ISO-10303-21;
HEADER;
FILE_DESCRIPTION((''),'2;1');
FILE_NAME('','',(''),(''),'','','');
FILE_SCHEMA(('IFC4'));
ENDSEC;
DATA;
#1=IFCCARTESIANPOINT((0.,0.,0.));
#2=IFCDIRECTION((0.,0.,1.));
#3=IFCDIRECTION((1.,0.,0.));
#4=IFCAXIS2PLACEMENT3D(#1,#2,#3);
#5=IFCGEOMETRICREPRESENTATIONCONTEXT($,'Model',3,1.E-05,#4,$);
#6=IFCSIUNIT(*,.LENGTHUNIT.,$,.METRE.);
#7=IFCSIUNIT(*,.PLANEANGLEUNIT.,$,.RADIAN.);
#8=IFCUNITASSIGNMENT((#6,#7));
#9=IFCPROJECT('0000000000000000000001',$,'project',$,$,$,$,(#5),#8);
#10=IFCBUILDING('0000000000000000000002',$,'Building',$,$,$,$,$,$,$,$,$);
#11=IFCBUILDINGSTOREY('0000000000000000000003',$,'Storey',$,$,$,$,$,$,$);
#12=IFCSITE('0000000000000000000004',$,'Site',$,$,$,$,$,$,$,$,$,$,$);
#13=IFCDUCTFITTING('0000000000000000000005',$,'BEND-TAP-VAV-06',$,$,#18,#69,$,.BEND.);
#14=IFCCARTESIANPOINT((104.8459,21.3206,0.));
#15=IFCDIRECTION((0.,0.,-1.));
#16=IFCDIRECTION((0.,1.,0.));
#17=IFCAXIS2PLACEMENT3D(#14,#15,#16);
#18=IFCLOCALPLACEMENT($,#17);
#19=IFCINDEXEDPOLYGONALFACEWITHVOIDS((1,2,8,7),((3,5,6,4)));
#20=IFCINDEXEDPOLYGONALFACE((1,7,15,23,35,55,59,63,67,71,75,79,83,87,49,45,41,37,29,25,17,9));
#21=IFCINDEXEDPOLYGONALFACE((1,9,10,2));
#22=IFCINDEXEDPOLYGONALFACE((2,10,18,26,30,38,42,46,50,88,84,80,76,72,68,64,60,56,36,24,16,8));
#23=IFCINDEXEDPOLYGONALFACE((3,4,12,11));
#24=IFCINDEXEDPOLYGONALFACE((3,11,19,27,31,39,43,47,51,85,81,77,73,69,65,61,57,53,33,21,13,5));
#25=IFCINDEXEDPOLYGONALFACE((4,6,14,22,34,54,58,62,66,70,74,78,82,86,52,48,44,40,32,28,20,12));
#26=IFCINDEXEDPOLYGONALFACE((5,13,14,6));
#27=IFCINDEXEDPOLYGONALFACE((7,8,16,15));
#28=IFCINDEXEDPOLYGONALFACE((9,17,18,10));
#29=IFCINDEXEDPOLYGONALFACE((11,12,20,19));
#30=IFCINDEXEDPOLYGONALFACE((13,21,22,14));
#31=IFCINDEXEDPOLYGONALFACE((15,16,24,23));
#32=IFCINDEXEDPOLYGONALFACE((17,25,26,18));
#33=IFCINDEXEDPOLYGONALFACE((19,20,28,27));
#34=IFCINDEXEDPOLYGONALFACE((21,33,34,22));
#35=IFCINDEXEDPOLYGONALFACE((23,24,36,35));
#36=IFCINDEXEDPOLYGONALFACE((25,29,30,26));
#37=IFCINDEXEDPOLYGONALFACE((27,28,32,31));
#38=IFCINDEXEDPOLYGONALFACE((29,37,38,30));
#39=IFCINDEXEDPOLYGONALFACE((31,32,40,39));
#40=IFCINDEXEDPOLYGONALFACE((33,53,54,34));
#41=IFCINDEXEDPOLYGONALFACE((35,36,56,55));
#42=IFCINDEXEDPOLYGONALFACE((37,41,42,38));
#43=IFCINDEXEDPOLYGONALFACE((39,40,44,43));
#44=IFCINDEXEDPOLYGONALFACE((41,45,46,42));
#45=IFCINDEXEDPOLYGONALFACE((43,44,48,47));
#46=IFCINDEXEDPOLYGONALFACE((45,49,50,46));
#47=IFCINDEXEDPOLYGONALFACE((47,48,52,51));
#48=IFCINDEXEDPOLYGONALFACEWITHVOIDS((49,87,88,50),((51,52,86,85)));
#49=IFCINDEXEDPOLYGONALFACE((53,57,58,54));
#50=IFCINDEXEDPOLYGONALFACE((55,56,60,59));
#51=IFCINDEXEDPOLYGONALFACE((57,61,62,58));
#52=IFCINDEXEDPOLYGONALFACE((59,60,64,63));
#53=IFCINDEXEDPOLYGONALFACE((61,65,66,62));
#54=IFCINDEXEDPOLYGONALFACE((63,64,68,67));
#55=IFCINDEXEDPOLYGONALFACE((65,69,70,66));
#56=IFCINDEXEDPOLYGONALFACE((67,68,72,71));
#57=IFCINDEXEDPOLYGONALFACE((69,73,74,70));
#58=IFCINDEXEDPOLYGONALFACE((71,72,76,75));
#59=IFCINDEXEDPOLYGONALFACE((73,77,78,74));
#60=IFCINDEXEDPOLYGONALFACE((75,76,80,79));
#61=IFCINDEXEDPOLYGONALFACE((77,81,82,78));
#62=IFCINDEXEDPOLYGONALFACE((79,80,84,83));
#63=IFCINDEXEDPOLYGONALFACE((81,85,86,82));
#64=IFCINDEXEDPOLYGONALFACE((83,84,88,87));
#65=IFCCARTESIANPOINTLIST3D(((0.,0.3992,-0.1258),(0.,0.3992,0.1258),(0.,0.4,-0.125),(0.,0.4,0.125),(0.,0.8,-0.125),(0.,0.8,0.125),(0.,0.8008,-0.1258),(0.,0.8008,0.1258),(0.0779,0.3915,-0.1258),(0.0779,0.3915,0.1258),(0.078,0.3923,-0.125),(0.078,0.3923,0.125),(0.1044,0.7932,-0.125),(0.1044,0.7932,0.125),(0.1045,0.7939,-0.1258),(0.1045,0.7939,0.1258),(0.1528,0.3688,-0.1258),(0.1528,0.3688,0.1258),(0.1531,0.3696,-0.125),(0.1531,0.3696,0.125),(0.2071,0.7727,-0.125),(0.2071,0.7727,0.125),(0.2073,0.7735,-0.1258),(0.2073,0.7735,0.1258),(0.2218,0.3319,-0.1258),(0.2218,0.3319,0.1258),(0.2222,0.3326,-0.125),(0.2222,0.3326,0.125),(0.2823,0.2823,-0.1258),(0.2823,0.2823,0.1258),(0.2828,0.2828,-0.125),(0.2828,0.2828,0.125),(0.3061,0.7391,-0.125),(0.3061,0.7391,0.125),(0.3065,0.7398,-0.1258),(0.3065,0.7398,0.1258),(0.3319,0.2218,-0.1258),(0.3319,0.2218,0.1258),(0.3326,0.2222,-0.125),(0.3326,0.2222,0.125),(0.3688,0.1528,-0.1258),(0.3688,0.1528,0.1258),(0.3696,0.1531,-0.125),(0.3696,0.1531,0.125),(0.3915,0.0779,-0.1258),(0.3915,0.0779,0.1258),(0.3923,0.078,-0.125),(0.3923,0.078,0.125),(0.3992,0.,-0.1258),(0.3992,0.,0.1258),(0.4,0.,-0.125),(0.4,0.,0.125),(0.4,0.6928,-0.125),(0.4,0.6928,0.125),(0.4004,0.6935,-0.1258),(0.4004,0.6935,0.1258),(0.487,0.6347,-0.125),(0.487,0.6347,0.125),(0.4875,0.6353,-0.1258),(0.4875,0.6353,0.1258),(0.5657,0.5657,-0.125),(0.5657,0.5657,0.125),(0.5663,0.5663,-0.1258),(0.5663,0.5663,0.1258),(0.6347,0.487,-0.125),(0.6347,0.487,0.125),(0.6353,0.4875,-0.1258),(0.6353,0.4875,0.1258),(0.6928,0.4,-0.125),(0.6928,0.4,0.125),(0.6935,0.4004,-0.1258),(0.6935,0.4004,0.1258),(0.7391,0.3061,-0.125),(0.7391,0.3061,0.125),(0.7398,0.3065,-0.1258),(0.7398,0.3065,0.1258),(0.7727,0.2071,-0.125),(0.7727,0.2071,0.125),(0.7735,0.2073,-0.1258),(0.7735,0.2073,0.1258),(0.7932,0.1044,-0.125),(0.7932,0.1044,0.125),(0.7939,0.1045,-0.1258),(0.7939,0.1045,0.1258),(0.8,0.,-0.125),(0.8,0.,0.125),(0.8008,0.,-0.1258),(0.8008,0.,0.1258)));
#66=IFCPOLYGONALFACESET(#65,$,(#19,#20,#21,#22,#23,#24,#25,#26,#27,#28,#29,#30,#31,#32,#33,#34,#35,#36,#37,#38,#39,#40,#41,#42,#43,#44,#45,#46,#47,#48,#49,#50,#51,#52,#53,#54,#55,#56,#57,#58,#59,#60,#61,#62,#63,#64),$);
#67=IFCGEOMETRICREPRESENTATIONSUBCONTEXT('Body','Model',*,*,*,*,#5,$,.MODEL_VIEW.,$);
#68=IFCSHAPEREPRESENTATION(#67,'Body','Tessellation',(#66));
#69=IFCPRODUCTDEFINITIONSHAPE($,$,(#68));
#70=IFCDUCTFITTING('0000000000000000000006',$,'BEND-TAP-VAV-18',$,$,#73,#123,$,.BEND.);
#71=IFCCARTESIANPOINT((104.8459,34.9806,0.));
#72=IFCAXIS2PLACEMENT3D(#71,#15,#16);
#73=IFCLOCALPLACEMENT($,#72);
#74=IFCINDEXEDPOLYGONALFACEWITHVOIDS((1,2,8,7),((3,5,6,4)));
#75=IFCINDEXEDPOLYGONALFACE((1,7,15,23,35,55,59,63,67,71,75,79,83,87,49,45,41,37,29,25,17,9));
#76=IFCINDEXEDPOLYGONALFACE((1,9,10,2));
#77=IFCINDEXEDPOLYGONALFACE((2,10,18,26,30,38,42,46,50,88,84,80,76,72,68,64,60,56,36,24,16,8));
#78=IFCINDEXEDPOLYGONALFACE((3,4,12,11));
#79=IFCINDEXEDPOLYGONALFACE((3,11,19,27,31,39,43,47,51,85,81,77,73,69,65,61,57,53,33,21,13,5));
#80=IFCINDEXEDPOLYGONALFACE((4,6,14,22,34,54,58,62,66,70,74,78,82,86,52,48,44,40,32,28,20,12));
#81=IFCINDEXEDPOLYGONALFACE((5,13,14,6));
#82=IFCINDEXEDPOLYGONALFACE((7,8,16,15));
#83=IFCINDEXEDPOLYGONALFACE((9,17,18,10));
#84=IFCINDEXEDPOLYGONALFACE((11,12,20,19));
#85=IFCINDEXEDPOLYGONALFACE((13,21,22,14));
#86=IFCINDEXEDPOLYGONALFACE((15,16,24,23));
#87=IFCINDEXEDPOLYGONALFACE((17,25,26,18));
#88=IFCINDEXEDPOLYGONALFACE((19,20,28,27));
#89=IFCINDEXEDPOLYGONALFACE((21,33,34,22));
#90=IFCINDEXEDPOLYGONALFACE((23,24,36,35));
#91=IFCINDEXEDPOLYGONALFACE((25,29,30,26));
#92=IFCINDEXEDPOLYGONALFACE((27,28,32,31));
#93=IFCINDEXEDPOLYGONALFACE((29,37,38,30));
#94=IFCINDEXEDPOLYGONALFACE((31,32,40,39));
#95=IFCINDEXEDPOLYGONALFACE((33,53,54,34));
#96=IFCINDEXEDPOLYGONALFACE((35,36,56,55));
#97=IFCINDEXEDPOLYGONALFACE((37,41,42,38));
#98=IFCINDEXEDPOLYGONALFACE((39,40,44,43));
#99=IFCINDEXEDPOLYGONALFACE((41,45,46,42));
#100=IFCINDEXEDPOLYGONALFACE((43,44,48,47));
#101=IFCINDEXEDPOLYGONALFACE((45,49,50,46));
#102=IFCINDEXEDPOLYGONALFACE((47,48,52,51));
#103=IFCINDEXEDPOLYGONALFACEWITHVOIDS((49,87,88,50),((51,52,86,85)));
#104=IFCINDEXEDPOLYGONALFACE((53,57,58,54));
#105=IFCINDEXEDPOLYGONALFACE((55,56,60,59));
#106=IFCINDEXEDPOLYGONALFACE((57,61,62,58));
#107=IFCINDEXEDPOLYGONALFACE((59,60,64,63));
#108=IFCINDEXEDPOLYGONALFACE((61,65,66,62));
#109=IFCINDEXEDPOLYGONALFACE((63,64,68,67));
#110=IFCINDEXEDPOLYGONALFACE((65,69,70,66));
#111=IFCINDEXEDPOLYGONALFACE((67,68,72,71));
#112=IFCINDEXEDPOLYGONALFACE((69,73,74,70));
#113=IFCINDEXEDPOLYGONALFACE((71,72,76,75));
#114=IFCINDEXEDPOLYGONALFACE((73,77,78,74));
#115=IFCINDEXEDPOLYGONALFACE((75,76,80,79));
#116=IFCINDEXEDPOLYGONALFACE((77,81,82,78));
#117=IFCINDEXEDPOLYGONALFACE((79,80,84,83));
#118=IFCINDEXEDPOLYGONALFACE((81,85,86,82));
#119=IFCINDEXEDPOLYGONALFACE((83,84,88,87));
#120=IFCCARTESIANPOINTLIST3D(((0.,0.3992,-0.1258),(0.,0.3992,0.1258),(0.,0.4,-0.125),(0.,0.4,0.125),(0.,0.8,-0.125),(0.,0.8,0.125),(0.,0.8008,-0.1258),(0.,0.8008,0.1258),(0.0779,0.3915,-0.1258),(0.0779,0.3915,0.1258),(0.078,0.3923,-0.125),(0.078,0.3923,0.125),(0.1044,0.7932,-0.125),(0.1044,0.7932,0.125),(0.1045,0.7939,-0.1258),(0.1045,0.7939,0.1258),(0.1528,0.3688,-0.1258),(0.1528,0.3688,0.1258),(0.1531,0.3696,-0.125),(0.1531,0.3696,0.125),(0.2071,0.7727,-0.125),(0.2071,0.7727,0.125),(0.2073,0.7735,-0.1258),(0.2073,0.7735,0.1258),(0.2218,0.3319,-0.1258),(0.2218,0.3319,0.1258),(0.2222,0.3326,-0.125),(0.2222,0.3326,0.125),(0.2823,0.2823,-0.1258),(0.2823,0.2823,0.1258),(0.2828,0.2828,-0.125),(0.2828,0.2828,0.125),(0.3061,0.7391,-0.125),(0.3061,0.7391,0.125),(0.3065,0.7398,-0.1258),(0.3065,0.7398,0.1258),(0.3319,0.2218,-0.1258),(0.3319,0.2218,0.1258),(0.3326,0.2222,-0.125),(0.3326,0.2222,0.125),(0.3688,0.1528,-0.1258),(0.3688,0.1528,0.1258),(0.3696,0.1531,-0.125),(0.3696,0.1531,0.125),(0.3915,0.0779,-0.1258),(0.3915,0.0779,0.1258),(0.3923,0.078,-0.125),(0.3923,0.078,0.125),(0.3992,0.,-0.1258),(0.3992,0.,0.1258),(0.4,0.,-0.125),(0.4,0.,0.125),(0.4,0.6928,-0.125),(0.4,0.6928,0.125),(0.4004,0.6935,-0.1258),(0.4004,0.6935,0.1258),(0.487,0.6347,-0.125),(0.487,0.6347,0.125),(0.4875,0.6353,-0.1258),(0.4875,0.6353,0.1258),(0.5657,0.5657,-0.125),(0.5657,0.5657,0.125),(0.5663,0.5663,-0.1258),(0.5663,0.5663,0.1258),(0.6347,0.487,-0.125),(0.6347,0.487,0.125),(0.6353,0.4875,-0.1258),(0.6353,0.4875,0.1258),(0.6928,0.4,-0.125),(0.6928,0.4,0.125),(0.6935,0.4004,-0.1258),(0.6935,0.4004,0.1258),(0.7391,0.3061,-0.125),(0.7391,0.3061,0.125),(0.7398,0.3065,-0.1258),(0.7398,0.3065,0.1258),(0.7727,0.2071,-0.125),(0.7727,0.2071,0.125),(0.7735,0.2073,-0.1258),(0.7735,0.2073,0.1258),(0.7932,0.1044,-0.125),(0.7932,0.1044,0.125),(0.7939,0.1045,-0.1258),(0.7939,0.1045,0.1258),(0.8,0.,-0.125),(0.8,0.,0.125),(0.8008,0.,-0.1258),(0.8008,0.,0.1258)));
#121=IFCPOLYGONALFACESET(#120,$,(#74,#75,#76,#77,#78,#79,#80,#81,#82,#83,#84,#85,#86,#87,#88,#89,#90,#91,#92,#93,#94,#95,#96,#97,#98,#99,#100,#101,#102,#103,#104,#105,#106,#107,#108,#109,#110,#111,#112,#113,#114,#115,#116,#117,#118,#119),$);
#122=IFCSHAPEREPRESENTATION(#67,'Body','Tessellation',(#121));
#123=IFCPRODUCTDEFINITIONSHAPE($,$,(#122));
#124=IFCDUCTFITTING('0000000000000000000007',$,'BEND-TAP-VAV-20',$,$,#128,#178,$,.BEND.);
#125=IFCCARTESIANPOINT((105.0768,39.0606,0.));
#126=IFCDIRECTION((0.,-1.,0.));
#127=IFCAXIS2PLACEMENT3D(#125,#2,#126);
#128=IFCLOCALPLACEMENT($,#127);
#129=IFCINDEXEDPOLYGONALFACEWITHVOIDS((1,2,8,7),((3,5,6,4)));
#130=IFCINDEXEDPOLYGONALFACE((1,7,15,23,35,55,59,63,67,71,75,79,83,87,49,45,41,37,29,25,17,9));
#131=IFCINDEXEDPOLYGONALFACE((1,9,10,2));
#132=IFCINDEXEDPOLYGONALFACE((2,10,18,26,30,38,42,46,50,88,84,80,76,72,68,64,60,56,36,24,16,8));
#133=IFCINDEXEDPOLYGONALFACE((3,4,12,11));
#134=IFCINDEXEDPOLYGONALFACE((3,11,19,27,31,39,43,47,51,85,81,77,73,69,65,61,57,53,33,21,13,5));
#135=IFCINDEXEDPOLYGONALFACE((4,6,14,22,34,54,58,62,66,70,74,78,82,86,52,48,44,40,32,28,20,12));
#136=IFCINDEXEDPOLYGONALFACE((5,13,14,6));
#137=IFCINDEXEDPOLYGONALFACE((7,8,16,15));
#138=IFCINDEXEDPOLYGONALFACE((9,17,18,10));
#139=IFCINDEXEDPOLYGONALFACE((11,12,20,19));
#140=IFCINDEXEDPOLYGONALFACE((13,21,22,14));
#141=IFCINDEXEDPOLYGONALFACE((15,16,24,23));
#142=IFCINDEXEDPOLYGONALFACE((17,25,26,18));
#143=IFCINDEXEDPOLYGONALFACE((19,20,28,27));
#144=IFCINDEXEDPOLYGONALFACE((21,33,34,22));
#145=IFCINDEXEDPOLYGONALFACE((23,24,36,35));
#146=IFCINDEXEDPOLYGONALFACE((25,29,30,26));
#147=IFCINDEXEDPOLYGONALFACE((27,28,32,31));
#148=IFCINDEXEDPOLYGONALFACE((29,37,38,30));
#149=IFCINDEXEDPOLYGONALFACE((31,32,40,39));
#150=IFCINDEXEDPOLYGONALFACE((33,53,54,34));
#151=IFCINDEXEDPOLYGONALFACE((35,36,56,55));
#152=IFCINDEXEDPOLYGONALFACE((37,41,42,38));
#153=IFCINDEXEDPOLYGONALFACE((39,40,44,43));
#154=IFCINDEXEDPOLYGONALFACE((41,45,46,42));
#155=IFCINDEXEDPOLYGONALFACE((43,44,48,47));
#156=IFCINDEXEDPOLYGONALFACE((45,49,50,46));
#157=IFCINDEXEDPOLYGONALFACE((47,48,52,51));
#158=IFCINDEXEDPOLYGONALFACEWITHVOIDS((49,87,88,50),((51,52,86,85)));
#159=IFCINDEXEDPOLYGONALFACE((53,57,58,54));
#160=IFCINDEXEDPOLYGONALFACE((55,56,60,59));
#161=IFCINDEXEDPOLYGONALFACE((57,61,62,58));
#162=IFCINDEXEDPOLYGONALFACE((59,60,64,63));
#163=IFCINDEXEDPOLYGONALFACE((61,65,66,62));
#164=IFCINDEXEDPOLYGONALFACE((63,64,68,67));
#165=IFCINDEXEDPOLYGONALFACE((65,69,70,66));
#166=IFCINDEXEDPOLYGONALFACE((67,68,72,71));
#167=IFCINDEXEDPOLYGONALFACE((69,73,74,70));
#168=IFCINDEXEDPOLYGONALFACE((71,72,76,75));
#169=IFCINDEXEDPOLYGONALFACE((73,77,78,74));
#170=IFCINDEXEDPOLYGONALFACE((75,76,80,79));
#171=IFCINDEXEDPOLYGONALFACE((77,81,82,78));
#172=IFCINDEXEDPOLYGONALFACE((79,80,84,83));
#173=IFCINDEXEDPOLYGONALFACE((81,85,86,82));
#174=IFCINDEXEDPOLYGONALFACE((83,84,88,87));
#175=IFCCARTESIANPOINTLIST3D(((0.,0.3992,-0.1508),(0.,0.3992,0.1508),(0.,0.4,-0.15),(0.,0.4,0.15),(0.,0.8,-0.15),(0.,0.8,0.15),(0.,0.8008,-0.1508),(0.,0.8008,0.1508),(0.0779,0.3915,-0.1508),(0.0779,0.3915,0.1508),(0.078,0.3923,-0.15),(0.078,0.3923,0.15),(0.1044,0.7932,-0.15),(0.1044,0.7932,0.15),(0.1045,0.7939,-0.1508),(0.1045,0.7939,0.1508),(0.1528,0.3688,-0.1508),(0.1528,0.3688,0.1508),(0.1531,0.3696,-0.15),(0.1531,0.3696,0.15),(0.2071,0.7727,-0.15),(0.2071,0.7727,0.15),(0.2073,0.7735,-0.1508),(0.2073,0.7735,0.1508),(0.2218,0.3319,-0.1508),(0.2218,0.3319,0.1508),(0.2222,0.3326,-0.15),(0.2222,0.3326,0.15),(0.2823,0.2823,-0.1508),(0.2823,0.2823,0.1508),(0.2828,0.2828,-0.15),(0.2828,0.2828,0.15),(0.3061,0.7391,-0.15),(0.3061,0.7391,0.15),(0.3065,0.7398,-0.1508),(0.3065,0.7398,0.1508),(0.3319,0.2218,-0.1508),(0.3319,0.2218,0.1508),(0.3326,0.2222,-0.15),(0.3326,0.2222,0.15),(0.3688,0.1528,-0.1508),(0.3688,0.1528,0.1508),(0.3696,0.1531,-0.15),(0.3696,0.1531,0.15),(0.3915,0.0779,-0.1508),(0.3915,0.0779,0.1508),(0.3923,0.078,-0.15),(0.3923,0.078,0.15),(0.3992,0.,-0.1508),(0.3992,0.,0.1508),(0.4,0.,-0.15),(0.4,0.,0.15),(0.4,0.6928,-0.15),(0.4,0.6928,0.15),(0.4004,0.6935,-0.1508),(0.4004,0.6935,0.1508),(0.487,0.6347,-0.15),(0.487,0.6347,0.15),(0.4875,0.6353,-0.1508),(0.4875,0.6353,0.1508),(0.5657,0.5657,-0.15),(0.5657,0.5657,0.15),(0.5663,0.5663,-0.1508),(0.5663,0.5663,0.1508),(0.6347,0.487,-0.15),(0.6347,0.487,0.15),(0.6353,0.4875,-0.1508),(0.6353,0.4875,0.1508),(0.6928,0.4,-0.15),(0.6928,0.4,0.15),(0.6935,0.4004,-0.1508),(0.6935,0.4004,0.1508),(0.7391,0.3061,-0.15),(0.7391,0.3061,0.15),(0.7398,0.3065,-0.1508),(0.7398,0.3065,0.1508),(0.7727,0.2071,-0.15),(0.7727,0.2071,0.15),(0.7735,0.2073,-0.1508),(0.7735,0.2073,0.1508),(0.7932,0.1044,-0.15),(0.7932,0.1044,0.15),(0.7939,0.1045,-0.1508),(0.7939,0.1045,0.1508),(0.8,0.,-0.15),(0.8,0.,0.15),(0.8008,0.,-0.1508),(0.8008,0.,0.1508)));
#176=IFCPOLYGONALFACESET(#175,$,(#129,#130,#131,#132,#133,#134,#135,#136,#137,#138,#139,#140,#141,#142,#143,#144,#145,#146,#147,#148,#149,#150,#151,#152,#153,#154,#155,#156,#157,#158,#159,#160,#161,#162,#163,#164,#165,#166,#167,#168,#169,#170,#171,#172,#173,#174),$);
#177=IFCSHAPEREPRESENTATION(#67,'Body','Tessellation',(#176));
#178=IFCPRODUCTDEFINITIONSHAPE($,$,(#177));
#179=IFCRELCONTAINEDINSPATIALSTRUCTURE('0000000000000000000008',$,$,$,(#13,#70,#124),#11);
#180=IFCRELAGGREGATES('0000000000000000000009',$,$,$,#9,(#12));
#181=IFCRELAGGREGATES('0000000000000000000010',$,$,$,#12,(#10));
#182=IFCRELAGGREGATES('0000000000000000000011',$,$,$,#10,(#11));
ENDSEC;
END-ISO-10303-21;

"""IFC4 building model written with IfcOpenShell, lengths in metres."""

from ifc_helpers import new_model, entity, si_unit, frame, origin_with_axes, place, context, subcontext, project, spatial, element, save


model = new_model("IFC4")

# Units and contexts
model_context = context("Model", 3, precision=1e-05, world=origin_with_axes())
body_context = subcontext(model_context, "Body", "Model", "MODEL_VIEW")
ifc_project = project(units=[si_unit("LENGTHUNIT", "METRE"), si_unit("PLANEANGLEUNIT", "RADIAN")], contexts=[model_context])

# Site, building, storey
site = spatial("IfcSite", under=ifc_project, Name="Site")
building = spatial("IfcBuilding", under=site, Name="Building")
storey = spatial("IfcBuildingStorey", under=building, Name="Storey")

# Duct fittings
duct_fitting_1_placement = place(None, frame((104.8459, 21.3206, 0.0), z_axis=(0.0, 0.0, -1.0), x_axis=(0.0, 1.0, 0.0)))
cartesian_point_1 = entity("IfcCartesianPoint", [0.0, 0.0, 0.0])
element("IfcDuctFitting", 1, at=duct_fitting_1_placement, inside=storey, Name="BEND-TAP-VAV-06", PredefinedType="BEND", context=body_context, shape_type="SweptSolid", body=[
    entity("IfcRevolvedAreaSolid", entity("IfcRectangleHollowProfileDef", "AREA", None, entity("IfcAxis2Placement2D", entity("IfcCartesianPoint", [0.6, 0.0])), 0.4016, 0.2516, 0.0008), entity("IfcAxis2Placement3D", cartesian_point_1, entity("IfcDirection", [0.0, -1.0, 0.0]), entity("IfcDirection", [1.0, 0.0, 0.0])), entity("IfcAxis1Placement", cartesian_point_1, entity("IfcDirection", [0.0, 1.0, 0.0])), 1.570796),
])
duct_fitting_2_placement = place(None, frame((104.8459, 34.9806, 0.0), z_axis=(0.0, 0.0, -1.0), x_axis=(0.0, 1.0, 0.0)))
cartesian_point_2 = entity("IfcCartesianPoint", [0.0, 0.0, 0.0])
element("IfcDuctFitting", 2, at=duct_fitting_2_placement, inside=storey, Name="BEND-TAP-VAV-18", PredefinedType="BEND", context=body_context, shape_type="SweptSolid", body=[
    entity("IfcRevolvedAreaSolid", entity("IfcRectangleHollowProfileDef", "AREA", None, entity("IfcAxis2Placement2D", entity("IfcCartesianPoint", [0.6, 0.0])), 0.4016, 0.2516, 0.0008), entity("IfcAxis2Placement3D", cartesian_point_2, entity("IfcDirection", [0.0, -1.0, 0.0]), entity("IfcDirection", [1.0, 0.0, 0.0])), entity("IfcAxis1Placement", cartesian_point_2, entity("IfcDirection", [0.0, 1.0, 0.0])), 1.570796),
])
duct_fitting_3_placement = place(None, frame((105.0768, 39.0606, 0.0), z_axis=(0.0, 0.0, 1.0), x_axis=(0.0, -1.0, 0.0)))
cartesian_point_3 = entity("IfcCartesianPoint", [0.0, 0.0, 0.0])
element("IfcDuctFitting", 3, at=duct_fitting_3_placement, inside=storey, Name="BEND-TAP-VAV-20", PredefinedType="BEND", context=body_context, shape_type="SweptSolid", body=[
    entity("IfcRevolvedAreaSolid", entity("IfcRectangleHollowProfileDef", "AREA", None, entity("IfcAxis2Placement2D", entity("IfcCartesianPoint", [0.6, 0.0])), 0.4016, 0.3016, 0.0008), entity("IfcAxis2Placement3D", cartesian_point_3, entity("IfcDirection", [0.0, -1.0, 0.0]), entity("IfcDirection", [1.0, 0.0, 0.0])), entity("IfcAxis1Placement", cartesian_point_3, entity("IfcDirection", [0.0, 1.0, 0.0])), 1.570796),
])

save(model, "model.ifc")
